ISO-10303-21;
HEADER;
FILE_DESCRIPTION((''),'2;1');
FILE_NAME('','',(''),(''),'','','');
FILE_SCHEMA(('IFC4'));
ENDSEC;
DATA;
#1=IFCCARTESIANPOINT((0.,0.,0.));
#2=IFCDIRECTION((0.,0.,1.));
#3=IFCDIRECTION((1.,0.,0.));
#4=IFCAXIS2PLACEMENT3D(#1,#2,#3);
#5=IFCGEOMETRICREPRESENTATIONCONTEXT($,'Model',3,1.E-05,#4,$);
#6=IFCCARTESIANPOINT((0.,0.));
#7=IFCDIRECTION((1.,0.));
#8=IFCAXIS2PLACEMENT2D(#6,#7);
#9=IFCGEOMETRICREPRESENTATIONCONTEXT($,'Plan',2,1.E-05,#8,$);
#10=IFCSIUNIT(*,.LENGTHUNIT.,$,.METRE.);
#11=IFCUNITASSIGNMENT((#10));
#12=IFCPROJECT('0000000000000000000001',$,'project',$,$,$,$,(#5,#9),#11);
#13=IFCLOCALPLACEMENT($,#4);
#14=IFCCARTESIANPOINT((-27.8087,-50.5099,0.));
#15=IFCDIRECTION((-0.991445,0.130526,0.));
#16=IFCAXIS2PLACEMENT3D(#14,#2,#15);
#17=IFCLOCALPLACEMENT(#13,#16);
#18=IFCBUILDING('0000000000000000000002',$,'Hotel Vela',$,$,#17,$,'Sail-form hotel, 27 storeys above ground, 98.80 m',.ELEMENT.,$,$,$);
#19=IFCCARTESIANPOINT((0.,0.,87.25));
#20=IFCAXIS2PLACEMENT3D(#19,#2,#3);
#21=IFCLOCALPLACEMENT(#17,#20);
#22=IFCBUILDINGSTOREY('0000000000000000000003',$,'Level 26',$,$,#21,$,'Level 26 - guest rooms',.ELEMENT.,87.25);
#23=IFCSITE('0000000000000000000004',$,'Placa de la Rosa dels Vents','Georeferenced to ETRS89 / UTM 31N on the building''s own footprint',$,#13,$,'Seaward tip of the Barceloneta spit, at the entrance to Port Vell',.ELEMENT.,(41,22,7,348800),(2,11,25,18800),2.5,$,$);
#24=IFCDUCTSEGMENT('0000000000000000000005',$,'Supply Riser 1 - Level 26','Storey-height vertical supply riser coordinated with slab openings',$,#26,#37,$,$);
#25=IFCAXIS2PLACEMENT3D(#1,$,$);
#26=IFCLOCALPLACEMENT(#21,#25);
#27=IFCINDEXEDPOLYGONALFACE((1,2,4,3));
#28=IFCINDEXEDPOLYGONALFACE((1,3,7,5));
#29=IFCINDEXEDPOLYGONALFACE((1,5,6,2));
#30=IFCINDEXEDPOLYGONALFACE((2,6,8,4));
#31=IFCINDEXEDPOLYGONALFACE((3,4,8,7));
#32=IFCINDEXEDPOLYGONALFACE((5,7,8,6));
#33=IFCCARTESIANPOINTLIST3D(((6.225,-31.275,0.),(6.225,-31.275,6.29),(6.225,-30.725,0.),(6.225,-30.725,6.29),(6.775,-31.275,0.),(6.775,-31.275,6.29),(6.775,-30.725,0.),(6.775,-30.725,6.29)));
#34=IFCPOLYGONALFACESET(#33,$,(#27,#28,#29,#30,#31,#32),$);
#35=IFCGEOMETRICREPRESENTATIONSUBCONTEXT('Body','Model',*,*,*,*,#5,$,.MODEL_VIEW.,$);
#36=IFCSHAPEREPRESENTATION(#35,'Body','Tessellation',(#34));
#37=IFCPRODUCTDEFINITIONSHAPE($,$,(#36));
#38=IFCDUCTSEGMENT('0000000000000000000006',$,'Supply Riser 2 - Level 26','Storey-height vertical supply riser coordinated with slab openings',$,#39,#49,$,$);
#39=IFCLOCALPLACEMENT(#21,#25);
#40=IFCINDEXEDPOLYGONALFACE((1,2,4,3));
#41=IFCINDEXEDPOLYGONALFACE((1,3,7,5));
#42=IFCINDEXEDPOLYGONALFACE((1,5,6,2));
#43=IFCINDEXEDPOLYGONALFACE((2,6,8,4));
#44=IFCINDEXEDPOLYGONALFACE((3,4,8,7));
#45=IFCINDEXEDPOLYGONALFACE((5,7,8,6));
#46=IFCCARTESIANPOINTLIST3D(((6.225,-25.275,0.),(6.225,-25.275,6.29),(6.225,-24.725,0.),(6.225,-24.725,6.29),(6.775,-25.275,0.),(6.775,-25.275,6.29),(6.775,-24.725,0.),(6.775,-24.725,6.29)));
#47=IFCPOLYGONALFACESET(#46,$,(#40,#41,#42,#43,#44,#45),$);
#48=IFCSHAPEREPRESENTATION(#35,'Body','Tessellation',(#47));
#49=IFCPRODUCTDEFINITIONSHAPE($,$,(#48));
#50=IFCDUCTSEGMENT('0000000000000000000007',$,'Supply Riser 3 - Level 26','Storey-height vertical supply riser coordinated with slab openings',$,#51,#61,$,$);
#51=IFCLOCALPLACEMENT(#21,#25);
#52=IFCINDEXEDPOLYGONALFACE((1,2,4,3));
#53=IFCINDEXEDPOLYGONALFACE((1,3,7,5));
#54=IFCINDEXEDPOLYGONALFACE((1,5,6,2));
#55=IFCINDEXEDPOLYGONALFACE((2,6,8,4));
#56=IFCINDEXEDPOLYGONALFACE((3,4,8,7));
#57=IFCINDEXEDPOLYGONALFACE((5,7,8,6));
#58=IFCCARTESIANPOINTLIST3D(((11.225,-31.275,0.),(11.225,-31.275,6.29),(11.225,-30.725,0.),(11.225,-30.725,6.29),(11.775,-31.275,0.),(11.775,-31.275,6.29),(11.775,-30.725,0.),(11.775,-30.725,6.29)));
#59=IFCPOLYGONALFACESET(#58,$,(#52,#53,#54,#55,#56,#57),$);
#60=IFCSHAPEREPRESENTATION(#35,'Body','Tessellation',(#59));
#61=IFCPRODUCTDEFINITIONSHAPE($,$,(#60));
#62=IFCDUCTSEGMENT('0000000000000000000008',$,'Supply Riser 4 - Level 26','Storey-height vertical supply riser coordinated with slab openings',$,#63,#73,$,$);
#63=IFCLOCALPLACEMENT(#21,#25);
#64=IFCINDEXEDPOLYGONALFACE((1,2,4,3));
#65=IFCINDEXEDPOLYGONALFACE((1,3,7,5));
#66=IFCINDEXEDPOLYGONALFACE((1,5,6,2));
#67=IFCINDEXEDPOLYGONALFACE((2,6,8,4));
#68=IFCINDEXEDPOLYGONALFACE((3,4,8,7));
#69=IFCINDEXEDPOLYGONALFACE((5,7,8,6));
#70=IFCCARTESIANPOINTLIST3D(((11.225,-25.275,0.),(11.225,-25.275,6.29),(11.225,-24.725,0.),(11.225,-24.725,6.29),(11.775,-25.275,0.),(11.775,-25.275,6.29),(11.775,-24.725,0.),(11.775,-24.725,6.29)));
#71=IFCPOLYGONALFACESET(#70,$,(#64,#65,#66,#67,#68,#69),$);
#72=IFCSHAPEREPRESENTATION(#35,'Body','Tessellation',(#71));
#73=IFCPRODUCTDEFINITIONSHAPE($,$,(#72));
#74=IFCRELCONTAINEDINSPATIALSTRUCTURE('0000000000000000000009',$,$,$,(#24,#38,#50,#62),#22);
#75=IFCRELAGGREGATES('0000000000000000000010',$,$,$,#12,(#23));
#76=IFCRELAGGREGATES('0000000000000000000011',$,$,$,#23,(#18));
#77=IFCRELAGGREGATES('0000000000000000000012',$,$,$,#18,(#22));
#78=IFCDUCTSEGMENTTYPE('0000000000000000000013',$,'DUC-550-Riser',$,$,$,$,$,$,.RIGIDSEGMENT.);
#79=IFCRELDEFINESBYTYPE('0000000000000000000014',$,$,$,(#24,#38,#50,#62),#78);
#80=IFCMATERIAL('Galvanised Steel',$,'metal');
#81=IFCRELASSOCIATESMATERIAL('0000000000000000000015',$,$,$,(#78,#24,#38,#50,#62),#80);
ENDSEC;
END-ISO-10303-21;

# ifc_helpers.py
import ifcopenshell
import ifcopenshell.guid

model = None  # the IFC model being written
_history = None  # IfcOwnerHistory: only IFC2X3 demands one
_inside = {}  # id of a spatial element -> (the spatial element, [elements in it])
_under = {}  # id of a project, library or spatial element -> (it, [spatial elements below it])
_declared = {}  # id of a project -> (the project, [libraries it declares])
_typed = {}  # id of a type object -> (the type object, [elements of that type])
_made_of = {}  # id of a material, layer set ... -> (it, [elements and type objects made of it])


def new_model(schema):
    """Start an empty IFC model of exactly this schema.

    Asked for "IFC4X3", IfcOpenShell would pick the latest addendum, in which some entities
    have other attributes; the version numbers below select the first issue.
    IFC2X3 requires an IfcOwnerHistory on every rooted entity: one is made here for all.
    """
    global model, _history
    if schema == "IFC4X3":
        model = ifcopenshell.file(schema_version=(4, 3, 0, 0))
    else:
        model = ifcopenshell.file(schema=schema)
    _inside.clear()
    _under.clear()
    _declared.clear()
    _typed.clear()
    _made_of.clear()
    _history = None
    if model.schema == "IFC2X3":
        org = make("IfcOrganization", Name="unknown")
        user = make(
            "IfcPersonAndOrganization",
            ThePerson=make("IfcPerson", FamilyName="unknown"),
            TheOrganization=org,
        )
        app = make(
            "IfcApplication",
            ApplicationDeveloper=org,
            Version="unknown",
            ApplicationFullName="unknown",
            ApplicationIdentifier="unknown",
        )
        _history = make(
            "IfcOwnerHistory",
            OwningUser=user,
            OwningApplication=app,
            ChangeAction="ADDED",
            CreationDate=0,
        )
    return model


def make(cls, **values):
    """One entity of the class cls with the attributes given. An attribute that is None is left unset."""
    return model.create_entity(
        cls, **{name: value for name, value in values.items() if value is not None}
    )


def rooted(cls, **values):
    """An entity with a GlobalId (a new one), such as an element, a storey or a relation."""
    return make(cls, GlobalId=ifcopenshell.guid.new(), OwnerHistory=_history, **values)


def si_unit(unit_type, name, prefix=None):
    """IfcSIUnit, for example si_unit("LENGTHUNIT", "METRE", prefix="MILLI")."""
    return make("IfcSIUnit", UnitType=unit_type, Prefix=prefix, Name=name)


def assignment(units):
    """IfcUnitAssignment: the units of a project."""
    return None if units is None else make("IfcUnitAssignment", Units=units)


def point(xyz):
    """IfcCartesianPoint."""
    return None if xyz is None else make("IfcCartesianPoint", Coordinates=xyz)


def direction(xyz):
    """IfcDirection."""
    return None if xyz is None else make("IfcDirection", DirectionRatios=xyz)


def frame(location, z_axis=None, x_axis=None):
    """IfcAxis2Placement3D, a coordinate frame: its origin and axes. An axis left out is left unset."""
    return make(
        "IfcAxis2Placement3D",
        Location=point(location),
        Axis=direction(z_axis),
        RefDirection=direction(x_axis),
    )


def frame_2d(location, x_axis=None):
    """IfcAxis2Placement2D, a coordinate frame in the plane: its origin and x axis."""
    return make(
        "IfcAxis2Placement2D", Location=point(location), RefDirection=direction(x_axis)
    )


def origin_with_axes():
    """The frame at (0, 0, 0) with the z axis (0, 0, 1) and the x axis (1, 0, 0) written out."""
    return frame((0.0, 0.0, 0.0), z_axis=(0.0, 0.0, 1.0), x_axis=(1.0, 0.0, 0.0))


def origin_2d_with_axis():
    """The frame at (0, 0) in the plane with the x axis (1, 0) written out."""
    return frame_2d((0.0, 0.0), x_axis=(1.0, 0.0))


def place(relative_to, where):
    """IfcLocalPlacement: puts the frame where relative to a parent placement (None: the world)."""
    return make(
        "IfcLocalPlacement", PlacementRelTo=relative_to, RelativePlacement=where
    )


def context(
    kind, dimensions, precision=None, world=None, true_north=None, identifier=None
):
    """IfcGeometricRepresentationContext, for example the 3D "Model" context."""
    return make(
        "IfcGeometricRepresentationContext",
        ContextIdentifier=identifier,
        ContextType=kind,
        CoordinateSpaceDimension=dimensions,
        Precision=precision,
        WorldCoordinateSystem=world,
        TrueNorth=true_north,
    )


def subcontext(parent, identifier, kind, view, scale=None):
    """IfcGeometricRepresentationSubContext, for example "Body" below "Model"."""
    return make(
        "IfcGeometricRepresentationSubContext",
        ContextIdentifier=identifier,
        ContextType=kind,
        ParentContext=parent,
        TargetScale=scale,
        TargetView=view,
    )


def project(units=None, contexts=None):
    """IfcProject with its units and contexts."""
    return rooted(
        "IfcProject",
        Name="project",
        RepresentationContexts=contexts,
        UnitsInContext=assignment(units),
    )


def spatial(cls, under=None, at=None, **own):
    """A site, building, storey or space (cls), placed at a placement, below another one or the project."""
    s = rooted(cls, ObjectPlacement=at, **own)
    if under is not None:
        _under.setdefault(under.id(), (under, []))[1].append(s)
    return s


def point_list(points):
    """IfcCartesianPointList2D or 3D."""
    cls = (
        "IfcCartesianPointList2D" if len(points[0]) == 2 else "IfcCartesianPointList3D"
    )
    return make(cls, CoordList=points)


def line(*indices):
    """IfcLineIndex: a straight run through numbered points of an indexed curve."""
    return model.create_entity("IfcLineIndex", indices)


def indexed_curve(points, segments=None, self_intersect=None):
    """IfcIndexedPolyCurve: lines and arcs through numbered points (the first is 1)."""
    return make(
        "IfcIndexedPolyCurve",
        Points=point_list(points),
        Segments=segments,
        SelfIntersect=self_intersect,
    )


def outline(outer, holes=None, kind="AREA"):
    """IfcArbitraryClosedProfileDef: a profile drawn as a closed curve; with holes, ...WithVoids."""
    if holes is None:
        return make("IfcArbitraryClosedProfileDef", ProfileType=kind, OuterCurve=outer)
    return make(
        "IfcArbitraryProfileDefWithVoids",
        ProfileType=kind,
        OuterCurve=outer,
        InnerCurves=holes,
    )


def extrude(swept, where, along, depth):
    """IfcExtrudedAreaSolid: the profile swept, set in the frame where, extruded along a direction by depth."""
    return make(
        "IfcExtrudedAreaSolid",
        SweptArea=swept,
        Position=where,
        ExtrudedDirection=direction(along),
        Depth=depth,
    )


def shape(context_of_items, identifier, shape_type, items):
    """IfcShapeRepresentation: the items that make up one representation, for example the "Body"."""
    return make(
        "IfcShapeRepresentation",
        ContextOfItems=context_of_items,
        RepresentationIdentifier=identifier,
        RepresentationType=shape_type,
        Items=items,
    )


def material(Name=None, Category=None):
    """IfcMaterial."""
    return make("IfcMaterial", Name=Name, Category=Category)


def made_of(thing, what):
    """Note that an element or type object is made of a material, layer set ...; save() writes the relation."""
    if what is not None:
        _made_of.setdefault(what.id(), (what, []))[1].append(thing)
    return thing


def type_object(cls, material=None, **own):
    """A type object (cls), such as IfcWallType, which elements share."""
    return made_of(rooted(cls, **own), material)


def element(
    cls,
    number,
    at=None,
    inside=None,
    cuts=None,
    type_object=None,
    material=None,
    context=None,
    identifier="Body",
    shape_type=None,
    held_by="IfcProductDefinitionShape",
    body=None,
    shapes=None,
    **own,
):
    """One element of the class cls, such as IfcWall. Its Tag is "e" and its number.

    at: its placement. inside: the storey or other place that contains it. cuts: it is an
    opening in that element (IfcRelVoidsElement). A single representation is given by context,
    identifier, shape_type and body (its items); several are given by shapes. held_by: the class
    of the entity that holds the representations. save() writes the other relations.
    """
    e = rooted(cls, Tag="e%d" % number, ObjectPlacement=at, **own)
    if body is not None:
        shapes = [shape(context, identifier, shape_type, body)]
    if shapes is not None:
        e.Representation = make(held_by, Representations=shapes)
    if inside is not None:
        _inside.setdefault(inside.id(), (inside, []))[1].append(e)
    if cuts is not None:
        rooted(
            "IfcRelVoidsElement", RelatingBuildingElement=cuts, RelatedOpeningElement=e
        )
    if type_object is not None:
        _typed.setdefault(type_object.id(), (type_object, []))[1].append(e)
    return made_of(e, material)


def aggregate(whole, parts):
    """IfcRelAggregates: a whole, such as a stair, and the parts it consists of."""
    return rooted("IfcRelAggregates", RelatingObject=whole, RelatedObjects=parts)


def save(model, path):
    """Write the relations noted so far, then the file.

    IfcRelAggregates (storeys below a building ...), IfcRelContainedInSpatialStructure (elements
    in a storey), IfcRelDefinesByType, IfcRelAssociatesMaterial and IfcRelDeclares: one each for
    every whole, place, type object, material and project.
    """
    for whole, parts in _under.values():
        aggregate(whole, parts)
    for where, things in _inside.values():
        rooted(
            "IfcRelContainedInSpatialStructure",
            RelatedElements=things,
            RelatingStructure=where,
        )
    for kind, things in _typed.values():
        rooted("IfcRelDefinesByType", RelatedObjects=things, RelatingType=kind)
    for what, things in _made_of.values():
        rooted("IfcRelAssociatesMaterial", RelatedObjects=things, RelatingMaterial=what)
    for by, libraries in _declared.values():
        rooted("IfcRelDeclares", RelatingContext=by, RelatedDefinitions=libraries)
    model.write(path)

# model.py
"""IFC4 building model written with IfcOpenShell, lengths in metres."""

from ifc_helpers import new_model, si_unit, frame, origin_with_axes, origin_2d_with_axis, place, context, subcontext, project, spatial, line, indexed_curve, outline, extrude, material, type_object, element, save


model = new_model("IFC4")

# Units and contexts
model_context = context("Model", 3, precision=1e-05, world=origin_with_axes())
plan_context = context("Plan", 2, precision=1e-05, world=origin_2d_with_axis())
body_context = subcontext(model_context, "Body", "Model", "MODEL_VIEW")
ifc_project = project(units=[si_unit("LENGTHUNIT", "METRE")], contexts=[model_context, plan_context])

# Site, building, storey
site_placement = place(None, origin_with_axes())
site = spatial("IfcSite", under=ifc_project, at=site_placement, Name="Placa de la Rosa dels Vents", Description="Georeferenced to ETRS89 / UTM 31N on the building's own footprint", LongName="Seaward tip of the Barceloneta spit, at the entrance to Port Vell", CompositionType="ELEMENT", RefLatitude=(41, 22, 7, 348800), RefLongitude=(2, 11, 25, 18800), RefElevation=2.5)
building_placement = place(site_placement, frame((-27.8087, -50.5099, 0.0), z_axis=(0.0, 0.0, 1.0), x_axis=(-0.991445, 0.130526, 0.0)))
building = spatial("IfcBuilding", under=site, at=building_placement, Name="Hotel Vela", LongName="Sail-form hotel, 27 storeys above ground, 98.80 m", CompositionType="ELEMENT")
storey_placement = place(building_placement, frame((0.0, 0.0, 87.25), z_axis=(0.0, 0.0, 1.0), x_axis=(1.0, 0.0, 0.0)))
storey = spatial("IfcBuildingStorey", under=building, at=storey_placement, Name="Level 26", LongName="Level 26 - guest rooms", CompositionType="ELEMENT", Elevation=87.25)

# Duct segments
ifc_material = material(Name="Galvanised Steel", Category="metal")
duct_segment_type = type_object("IfcDuctSegmentType", Name="DUC-550-Riser", PredefinedType="RIGIDSEGMENT", material=ifc_material)
for number, where, z_axis, x_axis, name in (
    (1, (6.225, -31.275, 0.0), (0.0, 0.0, 1.0), (1.0, 0.0, 0.0), "Supply Riser 1 - Level 26"),
    (2, (6.225, -25.275, 0.0), (0.0, 0.0, 1.0), (1.0, 0.0, 0.0), "Supply Riser 2 - Level 26"),
    (3, (11.225, -31.275, 0.0), (0.0, 0.0, 1.0), (1.0, 0.0, 0.0), "Supply Riser 3 - Level 26"),
    (4, (11.225, -25.275, 0.0), (0.0, 0.0, 1.0), (1.0, 0.0, 0.0), "Supply Riser 4 - Level 26"),
):
    element("IfcDuctSegment", number, at=place(storey_placement, frame(where, z_axis=z_axis, x_axis=x_axis)), inside=storey, type_object=duct_segment_type, material=ifc_material, Name=name, Description="Storey-height vertical supply riser coordinated with slab openings", context=body_context, shape_type="SweptSolid", body=[
        extrude(outline(indexed_curve([(0.0, 0.0), (0.55, 0.0), (0.55, 0.55), (0.0, 0.55)], segments=[line(1, 2, 3, 4, 1)])), origin_with_axes(), (0.0, 0.0, 1.0), 6.29),
    ])

save(model, "model.ifc")
